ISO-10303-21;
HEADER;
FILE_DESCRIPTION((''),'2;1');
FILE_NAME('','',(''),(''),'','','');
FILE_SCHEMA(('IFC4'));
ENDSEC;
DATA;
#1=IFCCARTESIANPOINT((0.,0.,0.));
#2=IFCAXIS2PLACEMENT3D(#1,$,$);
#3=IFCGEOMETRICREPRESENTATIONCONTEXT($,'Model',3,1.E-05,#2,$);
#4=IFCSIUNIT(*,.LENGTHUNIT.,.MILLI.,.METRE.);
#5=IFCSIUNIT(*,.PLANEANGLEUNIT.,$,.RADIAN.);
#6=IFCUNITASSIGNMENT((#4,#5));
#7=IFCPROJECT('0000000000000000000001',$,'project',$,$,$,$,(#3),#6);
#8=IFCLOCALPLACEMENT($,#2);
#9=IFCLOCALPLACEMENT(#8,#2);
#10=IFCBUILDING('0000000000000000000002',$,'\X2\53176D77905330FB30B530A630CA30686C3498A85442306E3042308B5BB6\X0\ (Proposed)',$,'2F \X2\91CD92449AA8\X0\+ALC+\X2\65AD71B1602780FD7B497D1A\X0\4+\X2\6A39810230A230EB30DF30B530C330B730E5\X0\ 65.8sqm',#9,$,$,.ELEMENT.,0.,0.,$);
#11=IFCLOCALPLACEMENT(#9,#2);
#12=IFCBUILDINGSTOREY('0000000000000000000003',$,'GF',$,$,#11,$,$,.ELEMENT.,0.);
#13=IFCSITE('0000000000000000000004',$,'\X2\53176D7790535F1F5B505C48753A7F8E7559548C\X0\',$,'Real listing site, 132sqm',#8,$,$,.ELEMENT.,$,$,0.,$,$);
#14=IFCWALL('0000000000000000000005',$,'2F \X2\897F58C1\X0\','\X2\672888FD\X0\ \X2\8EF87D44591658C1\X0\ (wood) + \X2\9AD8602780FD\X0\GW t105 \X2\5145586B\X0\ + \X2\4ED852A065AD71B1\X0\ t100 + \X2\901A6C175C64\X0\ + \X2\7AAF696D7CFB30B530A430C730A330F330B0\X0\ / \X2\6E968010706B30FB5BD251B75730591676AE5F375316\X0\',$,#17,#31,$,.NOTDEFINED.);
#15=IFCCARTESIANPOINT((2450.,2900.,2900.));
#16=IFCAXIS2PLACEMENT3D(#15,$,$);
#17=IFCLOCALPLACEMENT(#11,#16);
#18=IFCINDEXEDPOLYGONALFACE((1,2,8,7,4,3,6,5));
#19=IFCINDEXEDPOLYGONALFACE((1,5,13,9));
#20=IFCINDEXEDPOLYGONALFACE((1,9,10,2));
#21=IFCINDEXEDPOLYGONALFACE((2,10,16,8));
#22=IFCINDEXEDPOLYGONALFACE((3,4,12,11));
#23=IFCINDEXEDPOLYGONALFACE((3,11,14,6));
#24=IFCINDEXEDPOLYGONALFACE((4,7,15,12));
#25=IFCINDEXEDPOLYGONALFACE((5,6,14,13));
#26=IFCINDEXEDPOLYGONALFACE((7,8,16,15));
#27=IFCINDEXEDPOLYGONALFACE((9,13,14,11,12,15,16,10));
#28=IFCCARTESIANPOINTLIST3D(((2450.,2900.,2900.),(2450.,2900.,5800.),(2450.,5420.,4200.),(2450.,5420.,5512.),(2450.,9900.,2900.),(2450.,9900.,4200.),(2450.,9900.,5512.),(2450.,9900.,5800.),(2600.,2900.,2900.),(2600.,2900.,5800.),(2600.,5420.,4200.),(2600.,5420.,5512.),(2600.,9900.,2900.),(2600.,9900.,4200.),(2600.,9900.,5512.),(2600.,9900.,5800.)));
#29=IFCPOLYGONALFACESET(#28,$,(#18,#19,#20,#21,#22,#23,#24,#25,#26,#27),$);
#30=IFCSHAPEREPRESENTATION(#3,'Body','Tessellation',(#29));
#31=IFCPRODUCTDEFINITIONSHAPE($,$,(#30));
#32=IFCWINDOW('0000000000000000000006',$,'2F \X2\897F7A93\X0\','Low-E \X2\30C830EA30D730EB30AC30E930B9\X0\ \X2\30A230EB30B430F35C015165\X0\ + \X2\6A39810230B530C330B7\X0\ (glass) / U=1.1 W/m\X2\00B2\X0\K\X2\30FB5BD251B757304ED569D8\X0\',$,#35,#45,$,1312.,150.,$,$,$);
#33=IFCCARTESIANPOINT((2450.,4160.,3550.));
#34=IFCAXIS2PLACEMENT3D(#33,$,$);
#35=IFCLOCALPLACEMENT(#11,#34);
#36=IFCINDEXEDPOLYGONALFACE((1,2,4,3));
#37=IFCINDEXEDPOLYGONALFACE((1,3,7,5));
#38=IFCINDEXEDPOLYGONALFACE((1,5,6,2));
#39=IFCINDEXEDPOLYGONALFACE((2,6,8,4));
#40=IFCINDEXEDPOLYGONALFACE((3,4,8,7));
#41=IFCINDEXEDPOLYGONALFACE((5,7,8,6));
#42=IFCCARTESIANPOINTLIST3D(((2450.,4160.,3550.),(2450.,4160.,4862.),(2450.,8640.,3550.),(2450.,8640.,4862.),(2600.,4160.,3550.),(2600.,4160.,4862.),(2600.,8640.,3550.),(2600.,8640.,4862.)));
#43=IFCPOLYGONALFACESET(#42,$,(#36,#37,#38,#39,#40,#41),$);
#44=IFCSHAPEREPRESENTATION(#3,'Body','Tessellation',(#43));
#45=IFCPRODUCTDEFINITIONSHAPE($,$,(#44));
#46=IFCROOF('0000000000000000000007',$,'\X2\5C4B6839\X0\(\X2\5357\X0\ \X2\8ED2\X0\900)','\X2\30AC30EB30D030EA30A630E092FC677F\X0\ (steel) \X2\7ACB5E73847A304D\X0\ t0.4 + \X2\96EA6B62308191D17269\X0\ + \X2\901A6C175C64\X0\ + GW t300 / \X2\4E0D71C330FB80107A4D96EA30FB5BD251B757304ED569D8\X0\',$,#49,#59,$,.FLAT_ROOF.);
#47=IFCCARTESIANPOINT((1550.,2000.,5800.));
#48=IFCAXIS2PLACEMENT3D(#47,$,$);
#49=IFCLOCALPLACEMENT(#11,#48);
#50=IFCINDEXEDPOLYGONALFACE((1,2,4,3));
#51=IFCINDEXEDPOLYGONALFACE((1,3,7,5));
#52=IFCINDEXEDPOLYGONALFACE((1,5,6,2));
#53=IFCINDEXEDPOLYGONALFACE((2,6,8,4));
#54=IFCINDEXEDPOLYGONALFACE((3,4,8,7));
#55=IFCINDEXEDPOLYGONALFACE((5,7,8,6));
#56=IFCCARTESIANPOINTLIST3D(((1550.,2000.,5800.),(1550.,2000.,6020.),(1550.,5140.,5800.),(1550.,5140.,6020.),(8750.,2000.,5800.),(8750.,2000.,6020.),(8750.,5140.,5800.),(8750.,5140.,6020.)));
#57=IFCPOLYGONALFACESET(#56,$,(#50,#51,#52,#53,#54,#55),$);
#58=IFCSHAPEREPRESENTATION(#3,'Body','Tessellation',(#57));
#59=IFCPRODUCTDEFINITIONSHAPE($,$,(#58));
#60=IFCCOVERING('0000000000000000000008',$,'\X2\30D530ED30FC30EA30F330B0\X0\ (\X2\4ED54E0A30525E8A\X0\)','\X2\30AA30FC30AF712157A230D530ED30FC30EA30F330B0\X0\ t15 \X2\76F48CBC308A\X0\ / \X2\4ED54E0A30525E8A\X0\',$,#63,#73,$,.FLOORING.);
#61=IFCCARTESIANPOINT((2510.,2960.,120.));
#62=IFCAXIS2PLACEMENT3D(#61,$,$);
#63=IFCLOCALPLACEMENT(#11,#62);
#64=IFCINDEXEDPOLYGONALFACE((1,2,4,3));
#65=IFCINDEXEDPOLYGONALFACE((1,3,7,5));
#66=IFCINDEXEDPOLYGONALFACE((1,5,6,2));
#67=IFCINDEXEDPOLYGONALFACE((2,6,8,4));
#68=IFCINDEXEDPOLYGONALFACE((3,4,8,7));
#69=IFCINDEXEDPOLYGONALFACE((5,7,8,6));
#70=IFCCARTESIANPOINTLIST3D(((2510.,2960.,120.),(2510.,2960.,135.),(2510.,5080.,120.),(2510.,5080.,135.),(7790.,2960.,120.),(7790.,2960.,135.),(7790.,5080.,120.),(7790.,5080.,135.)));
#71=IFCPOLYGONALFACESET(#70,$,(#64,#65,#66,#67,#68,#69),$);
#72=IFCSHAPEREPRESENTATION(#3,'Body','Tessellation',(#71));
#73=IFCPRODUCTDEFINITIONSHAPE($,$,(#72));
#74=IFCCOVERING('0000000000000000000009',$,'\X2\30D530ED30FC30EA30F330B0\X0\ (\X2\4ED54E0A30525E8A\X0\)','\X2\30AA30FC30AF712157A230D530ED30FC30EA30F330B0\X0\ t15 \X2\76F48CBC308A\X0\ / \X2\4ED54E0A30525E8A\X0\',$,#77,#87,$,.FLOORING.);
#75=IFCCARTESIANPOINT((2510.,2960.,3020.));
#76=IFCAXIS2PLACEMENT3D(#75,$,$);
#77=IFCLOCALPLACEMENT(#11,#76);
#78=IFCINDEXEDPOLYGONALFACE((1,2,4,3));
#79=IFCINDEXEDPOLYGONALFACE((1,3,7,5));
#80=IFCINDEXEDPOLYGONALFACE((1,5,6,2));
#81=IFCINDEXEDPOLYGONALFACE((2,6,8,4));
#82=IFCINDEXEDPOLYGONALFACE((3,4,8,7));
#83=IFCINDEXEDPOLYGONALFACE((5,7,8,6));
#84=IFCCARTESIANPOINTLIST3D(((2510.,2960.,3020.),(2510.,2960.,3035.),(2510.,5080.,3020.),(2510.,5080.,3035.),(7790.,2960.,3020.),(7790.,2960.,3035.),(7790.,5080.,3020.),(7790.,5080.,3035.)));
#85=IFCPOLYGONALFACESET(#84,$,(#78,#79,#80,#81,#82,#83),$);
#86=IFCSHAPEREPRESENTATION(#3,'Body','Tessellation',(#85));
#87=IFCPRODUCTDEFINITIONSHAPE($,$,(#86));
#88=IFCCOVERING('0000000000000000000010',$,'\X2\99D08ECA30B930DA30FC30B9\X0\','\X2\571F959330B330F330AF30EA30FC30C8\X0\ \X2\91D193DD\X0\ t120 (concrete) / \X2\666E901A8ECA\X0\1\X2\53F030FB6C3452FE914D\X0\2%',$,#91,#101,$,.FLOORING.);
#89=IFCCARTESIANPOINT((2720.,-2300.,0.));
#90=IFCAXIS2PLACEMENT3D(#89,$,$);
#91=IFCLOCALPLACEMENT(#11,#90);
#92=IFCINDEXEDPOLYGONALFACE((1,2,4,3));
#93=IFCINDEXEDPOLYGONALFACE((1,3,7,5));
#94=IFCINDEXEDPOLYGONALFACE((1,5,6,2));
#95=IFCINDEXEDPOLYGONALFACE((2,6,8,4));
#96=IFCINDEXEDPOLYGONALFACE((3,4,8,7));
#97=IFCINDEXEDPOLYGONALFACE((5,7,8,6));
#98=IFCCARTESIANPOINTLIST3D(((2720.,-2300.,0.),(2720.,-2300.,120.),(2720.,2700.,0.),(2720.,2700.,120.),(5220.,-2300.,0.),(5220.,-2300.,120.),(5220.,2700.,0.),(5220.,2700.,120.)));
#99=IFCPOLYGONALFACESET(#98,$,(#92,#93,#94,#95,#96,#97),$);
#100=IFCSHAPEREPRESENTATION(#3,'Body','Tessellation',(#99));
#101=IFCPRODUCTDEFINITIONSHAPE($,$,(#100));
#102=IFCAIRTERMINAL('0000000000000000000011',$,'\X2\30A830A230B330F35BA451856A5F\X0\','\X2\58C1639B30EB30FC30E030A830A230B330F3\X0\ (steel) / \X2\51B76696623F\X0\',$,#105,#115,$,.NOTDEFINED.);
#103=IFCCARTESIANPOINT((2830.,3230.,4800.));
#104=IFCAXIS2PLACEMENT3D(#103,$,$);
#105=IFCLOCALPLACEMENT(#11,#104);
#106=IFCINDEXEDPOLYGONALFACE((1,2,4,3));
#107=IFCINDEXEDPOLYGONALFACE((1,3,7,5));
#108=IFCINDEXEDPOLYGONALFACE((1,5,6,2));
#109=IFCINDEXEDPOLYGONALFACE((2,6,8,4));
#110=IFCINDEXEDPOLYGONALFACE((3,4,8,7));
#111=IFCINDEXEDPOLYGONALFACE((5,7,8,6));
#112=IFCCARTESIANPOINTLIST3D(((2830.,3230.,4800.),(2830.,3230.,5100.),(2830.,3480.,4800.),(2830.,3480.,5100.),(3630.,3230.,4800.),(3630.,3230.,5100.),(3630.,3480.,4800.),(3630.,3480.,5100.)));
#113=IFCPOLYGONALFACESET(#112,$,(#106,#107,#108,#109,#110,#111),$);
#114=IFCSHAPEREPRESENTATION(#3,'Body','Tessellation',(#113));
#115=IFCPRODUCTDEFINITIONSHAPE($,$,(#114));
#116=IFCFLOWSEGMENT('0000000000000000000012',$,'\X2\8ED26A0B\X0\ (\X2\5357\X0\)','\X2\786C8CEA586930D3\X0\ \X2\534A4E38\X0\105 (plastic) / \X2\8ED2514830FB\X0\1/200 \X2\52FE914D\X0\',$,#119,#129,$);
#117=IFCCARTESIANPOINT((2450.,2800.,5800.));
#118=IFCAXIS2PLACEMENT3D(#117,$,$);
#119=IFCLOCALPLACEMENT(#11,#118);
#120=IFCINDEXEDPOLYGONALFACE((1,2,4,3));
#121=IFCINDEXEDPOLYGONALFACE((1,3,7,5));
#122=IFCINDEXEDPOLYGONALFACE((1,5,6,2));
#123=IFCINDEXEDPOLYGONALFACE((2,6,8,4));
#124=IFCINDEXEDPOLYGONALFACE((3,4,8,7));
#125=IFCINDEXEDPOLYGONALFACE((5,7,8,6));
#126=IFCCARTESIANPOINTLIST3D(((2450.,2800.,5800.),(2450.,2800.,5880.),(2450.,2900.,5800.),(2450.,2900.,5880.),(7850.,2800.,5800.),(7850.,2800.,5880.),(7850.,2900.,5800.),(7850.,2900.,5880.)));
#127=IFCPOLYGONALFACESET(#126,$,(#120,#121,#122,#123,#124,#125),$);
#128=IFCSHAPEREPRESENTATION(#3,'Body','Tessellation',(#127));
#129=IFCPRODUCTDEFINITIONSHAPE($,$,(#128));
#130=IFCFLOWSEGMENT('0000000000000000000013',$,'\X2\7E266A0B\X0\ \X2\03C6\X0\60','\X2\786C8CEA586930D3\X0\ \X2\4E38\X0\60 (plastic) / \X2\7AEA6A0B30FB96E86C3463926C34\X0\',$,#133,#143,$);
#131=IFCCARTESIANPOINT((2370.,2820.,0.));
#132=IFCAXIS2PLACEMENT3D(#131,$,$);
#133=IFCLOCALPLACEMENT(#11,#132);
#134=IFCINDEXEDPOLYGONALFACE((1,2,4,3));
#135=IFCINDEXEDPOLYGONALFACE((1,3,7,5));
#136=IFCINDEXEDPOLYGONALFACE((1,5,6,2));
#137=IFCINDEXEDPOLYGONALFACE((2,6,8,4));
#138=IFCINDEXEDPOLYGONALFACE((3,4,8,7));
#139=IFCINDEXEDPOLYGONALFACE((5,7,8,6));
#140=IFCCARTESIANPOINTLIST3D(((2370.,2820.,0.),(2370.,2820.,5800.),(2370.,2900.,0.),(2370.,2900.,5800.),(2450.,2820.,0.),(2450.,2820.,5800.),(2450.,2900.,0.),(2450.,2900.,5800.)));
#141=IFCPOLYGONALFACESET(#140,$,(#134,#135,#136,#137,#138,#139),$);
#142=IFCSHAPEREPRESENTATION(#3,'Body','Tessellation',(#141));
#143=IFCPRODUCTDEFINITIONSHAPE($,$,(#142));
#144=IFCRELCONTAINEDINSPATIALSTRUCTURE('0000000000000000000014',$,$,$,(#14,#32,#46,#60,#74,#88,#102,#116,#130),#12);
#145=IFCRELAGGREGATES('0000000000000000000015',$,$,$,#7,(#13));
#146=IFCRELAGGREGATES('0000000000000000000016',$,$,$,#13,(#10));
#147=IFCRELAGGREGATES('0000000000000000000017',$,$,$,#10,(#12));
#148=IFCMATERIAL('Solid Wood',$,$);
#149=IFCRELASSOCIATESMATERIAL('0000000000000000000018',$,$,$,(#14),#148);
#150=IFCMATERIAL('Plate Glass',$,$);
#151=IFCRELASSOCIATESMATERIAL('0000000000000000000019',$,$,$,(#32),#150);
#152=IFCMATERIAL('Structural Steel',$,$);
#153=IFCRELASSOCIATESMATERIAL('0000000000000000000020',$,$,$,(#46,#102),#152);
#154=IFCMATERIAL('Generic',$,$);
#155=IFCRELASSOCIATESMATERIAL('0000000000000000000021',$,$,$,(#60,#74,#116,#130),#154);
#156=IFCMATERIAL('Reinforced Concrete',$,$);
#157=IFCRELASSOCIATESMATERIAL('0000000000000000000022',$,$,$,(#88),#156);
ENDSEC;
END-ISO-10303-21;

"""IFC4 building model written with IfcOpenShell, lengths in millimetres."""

from ifc_helpers import new_model, si_unit, frame, frame_2d, origin, place, context, project, spatial, rectangle, extrude, material, element, fill, save


model = new_model("IFC4")

# Units and contexts
model_context = context("Model", 3, precision=1e-05, world=origin())
ifc_project = project(units=[si_unit("LENGTHUNIT", "METRE", prefix="MILLI"), si_unit("PLANEANGLEUNIT", "RADIAN")], contexts=[model_context])

# Site, building, storey
site_placement = place(None, origin())
site = spatial("IfcSite", under=ifc_project, at=site_placement, Name="北海道弟子屈町美留和", ObjectType="Real listing site, 132sqm", CompositionType="ELEMENT", RefElevation=0.0)
building_placement = place(site_placement, origin())
building = spatial("IfcBuilding", under=site, at=building_placement, Name="北海道・サウナと水風呂のある家 (Proposed)", ObjectType="2F 重鉄骨+ALC+断熱性能等級4+樹脂アルミサッシュ 65.8sqm", CompositionType="ELEMENT", ElevationOfRefHeight=0.0, ElevationOfTerrain=0.0)
storey_placement = place(building_placement, origin())
storey = spatial("IfcBuildingStorey", under=building, at=storey_placement, Name="GF", CompositionType="ELEMENT", Elevation=0.0)

# Shared definitions
ifc_material_1 = material(Name="Solid Wood")

# Shared definitions
ifc_material_2 = material(Name="Reinforced Concrete")

# Shared definitions
ifc_material_3 = material(Name="Plate Glass")

# Wall, opening, window
wall_1_placement = place(storey_placement, frame((2450.0, 2900.0, 2900.0)))
wall_1 = element("IfcWall", 1, at=wall_1_placement, inside=storey, material=ifc_material_1, Name="2F 西壁", Description="木製 軸組外壁 (wood) + 高性能GW t105 充填 + 付加断熱 t100 + 通気層 + 窯業系サイディング / 準耐火・寒冷地外皮強化", PredefinedType="NOTDEFINED", context=model_context, shape_type="SweptSolid", body=[
    extrude(rectangle(XDim=150.0, YDim=7000.0, at=frame_2d((75.0, 3500.0))), frame((2450.0, 2900.0, 2900.0)), (0.0, 0.0, 1.0), 2900.0),
])
opening_1_placement = place(storey_placement, frame((2450.0, 4160.0, 3550.0)))
opening_1 = element("IfcOpeningElement", 2, at=opening_1_placement, cuts=wall_1, PredefinedType="NOTDEFINED", context=model_context, shape_type="SweptSolid", body=[
    extrude(rectangle(XDim=150.0, YDim=4480.0, at=frame_2d((75.0, 2240.0))), frame((2450.0, 4160.0, 3550.0)), (0.0, 0.0, 1.0), 1312.0),
])
window_1_placement = place(storey_placement, frame((2450.0, 4160.0, 3550.0)))
window_1 = element("IfcWindow", 3, at=window_1_placement, inside=storey, material=ifc_material_3, Name="2F 西窓", Description="Low-E トリプルガラス アルゴン封入 + 樹脂サッシ (glass) / U=1.1 W/m²K・寒冷地仕様", OverallHeight=1312.0, OverallWidth=150.0, context=model_context, shape_type="SweptSolid", body=[
    extrude(rectangle(XDim=150.0, YDim=4480.0, at=frame_2d((75.0, 2240.0))), frame((2450.0, 4160.0, 3550.0)), (0.0, 0.0, 1.0), 1312.0),
])
fill(opening_1, window_1)

# Roof
ifc_material_4 = material(Name="Structural Steel")
for number, where, name in (
    (4, (1550.0, 2000.0, 5800.0), "屋根(南 軒900)"),
):
    element("IfcRoof", number, at=place(storey_placement, frame(where)), inside=storey, material=ifc_material_4, Name=name, Description="ガルバリウム鋼板 (steel) 立平葺き t0.4 + 雪止め金物 + 通気層 + GW t300 / 不燃・耐積雪・寒冷地仕様", PredefinedType="FLAT_ROOF", context=model_context, shape_type="SweptSolid", body=[
        extrude(rectangle(XDim=7200.0, YDim=3140.0, at=frame_2d((3600.0, 1570.0))), frame((1550.0, 2000.0, 5800.0)), (0.0, 0.0, 1.0), 220.0),
    ])

# Coverings
ifc_material_5 = material(Name="Generic")
covering_1_placement = place(storey_placement, frame((2510.0, 2960.0, 120.0)))
element("IfcCovering", 5, at=covering_1_placement, inside=storey, material=ifc_material_5, Name="フローリング (仕上げ床)", Description="オーク無垢フローリング t15 直貼り / 仕上げ床", PredefinedType="FLOORING", context=model_context, shape_type="SweptSolid", body=[
    extrude(rectangle(XDim=5280.0, YDim=2120.0, at=frame_2d((2640.0, 1060.0))), frame((2510.0, 2960.0, 120.0)), (0.0, 0.0, 1.0), 15.0),
])
covering_2_placement = place(storey_placement, frame((2510.0, 2960.0, 3020.0)))
element("IfcCovering", 6, at=covering_2_placement, inside=storey, material=ifc_material_5, Name="フローリング (仕上げ床)", Description="オーク無垢フローリング t15 直貼り / 仕上げ床", PredefinedType="FLOORING", context=model_context, shape_type="SweptSolid", body=[
    extrude(rectangle(XDim=5280.0, YDim=2120.0, at=frame_2d((2640.0, 1060.0))), frame((2510.0, 2960.0, 3020.0)), (0.0, 0.0, 1.0), 15.0),
])
covering_3_placement = place(storey_placement, frame((2720.0, -2300.0, 0.0)))
element("IfcCovering", 7, at=covering_3_placement, inside=storey, material=ifc_material_2, Name="駐車スペース", Description="土間コンクリート 金鏝 t120 (concrete) / 普通車1台・水勾配2%", PredefinedType="FLOORING", context=model_context, shape_type="SweptSolid", body=[
    extrude(rectangle(XDim=2500.0, YDim=5000.0, at=frame_2d((1250.0, 2500.0))), frame((2720.0, -2300.0, 0.0)), (0.0, 0.0, 1.0), 120.0),
])

# Air terminal
air_terminal_placement = place(storey_placement, frame((2830.0, 3230.0, 4800.0)))
element("IfcAirTerminal", 8, at=air_terminal_placement, inside=storey, material=ifc_material_4, Name="エアコン室内機", Description="壁掛ルームエアコン (steel) / 冷暖房", PredefinedType="NOTDEFINED", context=model_context, shape_type="SweptSolid", body=[
    extrude(rectangle(XDim=800.0, YDim=250.0, at=frame_2d((400.0, 125.0))), frame((2830.0, 3230.0, 4800.0)), (0.0, 0.0, 1.0), 300.0),
])

# Flow segments
flow_segment_1_placement = place(storey_placement, frame((2450.0, 2800.0, 5800.0)))
element("IfcFlowSegment", 9, at=flow_segment_1_placement, inside=storey, material=ifc_material_5, Name="軒樋 (南)", Description="硬質塩ビ 半丸105 (plastic) / 軒先・1/200 勾配", context=model_context, shape_type="SweptSolid", body=[
    extrude(rectangle(XDim=5400.0, YDim=100.0, at=frame_2d((2700.0, 50.0))), frame((2450.0, 2800.0, 5800.0)), (0.0, 0.0, 1.0), 80.0),
])
flow_segment_2_placement = place(storey_placement, frame((2370.0, 2820.0, 0.0)))
element("IfcFlowSegment", 10, at=flow_segment_2_placement, inside=storey, material=ifc_material_5, Name="縦樋 φ60", Description="硬質塩ビ 丸60 (plastic) / 竪樋・雨水排水", context=model_context, shape_type="SweptSolid", body=[
    extrude(rectangle(XDim=80.0, YDim=80.0, at=frame_2d((40.0, 40.0))), frame((2370.0, 2820.0, 0.0)), (0.0, 0.0, 1.0), 5800.0),
])

save(model, "model.ifc")
